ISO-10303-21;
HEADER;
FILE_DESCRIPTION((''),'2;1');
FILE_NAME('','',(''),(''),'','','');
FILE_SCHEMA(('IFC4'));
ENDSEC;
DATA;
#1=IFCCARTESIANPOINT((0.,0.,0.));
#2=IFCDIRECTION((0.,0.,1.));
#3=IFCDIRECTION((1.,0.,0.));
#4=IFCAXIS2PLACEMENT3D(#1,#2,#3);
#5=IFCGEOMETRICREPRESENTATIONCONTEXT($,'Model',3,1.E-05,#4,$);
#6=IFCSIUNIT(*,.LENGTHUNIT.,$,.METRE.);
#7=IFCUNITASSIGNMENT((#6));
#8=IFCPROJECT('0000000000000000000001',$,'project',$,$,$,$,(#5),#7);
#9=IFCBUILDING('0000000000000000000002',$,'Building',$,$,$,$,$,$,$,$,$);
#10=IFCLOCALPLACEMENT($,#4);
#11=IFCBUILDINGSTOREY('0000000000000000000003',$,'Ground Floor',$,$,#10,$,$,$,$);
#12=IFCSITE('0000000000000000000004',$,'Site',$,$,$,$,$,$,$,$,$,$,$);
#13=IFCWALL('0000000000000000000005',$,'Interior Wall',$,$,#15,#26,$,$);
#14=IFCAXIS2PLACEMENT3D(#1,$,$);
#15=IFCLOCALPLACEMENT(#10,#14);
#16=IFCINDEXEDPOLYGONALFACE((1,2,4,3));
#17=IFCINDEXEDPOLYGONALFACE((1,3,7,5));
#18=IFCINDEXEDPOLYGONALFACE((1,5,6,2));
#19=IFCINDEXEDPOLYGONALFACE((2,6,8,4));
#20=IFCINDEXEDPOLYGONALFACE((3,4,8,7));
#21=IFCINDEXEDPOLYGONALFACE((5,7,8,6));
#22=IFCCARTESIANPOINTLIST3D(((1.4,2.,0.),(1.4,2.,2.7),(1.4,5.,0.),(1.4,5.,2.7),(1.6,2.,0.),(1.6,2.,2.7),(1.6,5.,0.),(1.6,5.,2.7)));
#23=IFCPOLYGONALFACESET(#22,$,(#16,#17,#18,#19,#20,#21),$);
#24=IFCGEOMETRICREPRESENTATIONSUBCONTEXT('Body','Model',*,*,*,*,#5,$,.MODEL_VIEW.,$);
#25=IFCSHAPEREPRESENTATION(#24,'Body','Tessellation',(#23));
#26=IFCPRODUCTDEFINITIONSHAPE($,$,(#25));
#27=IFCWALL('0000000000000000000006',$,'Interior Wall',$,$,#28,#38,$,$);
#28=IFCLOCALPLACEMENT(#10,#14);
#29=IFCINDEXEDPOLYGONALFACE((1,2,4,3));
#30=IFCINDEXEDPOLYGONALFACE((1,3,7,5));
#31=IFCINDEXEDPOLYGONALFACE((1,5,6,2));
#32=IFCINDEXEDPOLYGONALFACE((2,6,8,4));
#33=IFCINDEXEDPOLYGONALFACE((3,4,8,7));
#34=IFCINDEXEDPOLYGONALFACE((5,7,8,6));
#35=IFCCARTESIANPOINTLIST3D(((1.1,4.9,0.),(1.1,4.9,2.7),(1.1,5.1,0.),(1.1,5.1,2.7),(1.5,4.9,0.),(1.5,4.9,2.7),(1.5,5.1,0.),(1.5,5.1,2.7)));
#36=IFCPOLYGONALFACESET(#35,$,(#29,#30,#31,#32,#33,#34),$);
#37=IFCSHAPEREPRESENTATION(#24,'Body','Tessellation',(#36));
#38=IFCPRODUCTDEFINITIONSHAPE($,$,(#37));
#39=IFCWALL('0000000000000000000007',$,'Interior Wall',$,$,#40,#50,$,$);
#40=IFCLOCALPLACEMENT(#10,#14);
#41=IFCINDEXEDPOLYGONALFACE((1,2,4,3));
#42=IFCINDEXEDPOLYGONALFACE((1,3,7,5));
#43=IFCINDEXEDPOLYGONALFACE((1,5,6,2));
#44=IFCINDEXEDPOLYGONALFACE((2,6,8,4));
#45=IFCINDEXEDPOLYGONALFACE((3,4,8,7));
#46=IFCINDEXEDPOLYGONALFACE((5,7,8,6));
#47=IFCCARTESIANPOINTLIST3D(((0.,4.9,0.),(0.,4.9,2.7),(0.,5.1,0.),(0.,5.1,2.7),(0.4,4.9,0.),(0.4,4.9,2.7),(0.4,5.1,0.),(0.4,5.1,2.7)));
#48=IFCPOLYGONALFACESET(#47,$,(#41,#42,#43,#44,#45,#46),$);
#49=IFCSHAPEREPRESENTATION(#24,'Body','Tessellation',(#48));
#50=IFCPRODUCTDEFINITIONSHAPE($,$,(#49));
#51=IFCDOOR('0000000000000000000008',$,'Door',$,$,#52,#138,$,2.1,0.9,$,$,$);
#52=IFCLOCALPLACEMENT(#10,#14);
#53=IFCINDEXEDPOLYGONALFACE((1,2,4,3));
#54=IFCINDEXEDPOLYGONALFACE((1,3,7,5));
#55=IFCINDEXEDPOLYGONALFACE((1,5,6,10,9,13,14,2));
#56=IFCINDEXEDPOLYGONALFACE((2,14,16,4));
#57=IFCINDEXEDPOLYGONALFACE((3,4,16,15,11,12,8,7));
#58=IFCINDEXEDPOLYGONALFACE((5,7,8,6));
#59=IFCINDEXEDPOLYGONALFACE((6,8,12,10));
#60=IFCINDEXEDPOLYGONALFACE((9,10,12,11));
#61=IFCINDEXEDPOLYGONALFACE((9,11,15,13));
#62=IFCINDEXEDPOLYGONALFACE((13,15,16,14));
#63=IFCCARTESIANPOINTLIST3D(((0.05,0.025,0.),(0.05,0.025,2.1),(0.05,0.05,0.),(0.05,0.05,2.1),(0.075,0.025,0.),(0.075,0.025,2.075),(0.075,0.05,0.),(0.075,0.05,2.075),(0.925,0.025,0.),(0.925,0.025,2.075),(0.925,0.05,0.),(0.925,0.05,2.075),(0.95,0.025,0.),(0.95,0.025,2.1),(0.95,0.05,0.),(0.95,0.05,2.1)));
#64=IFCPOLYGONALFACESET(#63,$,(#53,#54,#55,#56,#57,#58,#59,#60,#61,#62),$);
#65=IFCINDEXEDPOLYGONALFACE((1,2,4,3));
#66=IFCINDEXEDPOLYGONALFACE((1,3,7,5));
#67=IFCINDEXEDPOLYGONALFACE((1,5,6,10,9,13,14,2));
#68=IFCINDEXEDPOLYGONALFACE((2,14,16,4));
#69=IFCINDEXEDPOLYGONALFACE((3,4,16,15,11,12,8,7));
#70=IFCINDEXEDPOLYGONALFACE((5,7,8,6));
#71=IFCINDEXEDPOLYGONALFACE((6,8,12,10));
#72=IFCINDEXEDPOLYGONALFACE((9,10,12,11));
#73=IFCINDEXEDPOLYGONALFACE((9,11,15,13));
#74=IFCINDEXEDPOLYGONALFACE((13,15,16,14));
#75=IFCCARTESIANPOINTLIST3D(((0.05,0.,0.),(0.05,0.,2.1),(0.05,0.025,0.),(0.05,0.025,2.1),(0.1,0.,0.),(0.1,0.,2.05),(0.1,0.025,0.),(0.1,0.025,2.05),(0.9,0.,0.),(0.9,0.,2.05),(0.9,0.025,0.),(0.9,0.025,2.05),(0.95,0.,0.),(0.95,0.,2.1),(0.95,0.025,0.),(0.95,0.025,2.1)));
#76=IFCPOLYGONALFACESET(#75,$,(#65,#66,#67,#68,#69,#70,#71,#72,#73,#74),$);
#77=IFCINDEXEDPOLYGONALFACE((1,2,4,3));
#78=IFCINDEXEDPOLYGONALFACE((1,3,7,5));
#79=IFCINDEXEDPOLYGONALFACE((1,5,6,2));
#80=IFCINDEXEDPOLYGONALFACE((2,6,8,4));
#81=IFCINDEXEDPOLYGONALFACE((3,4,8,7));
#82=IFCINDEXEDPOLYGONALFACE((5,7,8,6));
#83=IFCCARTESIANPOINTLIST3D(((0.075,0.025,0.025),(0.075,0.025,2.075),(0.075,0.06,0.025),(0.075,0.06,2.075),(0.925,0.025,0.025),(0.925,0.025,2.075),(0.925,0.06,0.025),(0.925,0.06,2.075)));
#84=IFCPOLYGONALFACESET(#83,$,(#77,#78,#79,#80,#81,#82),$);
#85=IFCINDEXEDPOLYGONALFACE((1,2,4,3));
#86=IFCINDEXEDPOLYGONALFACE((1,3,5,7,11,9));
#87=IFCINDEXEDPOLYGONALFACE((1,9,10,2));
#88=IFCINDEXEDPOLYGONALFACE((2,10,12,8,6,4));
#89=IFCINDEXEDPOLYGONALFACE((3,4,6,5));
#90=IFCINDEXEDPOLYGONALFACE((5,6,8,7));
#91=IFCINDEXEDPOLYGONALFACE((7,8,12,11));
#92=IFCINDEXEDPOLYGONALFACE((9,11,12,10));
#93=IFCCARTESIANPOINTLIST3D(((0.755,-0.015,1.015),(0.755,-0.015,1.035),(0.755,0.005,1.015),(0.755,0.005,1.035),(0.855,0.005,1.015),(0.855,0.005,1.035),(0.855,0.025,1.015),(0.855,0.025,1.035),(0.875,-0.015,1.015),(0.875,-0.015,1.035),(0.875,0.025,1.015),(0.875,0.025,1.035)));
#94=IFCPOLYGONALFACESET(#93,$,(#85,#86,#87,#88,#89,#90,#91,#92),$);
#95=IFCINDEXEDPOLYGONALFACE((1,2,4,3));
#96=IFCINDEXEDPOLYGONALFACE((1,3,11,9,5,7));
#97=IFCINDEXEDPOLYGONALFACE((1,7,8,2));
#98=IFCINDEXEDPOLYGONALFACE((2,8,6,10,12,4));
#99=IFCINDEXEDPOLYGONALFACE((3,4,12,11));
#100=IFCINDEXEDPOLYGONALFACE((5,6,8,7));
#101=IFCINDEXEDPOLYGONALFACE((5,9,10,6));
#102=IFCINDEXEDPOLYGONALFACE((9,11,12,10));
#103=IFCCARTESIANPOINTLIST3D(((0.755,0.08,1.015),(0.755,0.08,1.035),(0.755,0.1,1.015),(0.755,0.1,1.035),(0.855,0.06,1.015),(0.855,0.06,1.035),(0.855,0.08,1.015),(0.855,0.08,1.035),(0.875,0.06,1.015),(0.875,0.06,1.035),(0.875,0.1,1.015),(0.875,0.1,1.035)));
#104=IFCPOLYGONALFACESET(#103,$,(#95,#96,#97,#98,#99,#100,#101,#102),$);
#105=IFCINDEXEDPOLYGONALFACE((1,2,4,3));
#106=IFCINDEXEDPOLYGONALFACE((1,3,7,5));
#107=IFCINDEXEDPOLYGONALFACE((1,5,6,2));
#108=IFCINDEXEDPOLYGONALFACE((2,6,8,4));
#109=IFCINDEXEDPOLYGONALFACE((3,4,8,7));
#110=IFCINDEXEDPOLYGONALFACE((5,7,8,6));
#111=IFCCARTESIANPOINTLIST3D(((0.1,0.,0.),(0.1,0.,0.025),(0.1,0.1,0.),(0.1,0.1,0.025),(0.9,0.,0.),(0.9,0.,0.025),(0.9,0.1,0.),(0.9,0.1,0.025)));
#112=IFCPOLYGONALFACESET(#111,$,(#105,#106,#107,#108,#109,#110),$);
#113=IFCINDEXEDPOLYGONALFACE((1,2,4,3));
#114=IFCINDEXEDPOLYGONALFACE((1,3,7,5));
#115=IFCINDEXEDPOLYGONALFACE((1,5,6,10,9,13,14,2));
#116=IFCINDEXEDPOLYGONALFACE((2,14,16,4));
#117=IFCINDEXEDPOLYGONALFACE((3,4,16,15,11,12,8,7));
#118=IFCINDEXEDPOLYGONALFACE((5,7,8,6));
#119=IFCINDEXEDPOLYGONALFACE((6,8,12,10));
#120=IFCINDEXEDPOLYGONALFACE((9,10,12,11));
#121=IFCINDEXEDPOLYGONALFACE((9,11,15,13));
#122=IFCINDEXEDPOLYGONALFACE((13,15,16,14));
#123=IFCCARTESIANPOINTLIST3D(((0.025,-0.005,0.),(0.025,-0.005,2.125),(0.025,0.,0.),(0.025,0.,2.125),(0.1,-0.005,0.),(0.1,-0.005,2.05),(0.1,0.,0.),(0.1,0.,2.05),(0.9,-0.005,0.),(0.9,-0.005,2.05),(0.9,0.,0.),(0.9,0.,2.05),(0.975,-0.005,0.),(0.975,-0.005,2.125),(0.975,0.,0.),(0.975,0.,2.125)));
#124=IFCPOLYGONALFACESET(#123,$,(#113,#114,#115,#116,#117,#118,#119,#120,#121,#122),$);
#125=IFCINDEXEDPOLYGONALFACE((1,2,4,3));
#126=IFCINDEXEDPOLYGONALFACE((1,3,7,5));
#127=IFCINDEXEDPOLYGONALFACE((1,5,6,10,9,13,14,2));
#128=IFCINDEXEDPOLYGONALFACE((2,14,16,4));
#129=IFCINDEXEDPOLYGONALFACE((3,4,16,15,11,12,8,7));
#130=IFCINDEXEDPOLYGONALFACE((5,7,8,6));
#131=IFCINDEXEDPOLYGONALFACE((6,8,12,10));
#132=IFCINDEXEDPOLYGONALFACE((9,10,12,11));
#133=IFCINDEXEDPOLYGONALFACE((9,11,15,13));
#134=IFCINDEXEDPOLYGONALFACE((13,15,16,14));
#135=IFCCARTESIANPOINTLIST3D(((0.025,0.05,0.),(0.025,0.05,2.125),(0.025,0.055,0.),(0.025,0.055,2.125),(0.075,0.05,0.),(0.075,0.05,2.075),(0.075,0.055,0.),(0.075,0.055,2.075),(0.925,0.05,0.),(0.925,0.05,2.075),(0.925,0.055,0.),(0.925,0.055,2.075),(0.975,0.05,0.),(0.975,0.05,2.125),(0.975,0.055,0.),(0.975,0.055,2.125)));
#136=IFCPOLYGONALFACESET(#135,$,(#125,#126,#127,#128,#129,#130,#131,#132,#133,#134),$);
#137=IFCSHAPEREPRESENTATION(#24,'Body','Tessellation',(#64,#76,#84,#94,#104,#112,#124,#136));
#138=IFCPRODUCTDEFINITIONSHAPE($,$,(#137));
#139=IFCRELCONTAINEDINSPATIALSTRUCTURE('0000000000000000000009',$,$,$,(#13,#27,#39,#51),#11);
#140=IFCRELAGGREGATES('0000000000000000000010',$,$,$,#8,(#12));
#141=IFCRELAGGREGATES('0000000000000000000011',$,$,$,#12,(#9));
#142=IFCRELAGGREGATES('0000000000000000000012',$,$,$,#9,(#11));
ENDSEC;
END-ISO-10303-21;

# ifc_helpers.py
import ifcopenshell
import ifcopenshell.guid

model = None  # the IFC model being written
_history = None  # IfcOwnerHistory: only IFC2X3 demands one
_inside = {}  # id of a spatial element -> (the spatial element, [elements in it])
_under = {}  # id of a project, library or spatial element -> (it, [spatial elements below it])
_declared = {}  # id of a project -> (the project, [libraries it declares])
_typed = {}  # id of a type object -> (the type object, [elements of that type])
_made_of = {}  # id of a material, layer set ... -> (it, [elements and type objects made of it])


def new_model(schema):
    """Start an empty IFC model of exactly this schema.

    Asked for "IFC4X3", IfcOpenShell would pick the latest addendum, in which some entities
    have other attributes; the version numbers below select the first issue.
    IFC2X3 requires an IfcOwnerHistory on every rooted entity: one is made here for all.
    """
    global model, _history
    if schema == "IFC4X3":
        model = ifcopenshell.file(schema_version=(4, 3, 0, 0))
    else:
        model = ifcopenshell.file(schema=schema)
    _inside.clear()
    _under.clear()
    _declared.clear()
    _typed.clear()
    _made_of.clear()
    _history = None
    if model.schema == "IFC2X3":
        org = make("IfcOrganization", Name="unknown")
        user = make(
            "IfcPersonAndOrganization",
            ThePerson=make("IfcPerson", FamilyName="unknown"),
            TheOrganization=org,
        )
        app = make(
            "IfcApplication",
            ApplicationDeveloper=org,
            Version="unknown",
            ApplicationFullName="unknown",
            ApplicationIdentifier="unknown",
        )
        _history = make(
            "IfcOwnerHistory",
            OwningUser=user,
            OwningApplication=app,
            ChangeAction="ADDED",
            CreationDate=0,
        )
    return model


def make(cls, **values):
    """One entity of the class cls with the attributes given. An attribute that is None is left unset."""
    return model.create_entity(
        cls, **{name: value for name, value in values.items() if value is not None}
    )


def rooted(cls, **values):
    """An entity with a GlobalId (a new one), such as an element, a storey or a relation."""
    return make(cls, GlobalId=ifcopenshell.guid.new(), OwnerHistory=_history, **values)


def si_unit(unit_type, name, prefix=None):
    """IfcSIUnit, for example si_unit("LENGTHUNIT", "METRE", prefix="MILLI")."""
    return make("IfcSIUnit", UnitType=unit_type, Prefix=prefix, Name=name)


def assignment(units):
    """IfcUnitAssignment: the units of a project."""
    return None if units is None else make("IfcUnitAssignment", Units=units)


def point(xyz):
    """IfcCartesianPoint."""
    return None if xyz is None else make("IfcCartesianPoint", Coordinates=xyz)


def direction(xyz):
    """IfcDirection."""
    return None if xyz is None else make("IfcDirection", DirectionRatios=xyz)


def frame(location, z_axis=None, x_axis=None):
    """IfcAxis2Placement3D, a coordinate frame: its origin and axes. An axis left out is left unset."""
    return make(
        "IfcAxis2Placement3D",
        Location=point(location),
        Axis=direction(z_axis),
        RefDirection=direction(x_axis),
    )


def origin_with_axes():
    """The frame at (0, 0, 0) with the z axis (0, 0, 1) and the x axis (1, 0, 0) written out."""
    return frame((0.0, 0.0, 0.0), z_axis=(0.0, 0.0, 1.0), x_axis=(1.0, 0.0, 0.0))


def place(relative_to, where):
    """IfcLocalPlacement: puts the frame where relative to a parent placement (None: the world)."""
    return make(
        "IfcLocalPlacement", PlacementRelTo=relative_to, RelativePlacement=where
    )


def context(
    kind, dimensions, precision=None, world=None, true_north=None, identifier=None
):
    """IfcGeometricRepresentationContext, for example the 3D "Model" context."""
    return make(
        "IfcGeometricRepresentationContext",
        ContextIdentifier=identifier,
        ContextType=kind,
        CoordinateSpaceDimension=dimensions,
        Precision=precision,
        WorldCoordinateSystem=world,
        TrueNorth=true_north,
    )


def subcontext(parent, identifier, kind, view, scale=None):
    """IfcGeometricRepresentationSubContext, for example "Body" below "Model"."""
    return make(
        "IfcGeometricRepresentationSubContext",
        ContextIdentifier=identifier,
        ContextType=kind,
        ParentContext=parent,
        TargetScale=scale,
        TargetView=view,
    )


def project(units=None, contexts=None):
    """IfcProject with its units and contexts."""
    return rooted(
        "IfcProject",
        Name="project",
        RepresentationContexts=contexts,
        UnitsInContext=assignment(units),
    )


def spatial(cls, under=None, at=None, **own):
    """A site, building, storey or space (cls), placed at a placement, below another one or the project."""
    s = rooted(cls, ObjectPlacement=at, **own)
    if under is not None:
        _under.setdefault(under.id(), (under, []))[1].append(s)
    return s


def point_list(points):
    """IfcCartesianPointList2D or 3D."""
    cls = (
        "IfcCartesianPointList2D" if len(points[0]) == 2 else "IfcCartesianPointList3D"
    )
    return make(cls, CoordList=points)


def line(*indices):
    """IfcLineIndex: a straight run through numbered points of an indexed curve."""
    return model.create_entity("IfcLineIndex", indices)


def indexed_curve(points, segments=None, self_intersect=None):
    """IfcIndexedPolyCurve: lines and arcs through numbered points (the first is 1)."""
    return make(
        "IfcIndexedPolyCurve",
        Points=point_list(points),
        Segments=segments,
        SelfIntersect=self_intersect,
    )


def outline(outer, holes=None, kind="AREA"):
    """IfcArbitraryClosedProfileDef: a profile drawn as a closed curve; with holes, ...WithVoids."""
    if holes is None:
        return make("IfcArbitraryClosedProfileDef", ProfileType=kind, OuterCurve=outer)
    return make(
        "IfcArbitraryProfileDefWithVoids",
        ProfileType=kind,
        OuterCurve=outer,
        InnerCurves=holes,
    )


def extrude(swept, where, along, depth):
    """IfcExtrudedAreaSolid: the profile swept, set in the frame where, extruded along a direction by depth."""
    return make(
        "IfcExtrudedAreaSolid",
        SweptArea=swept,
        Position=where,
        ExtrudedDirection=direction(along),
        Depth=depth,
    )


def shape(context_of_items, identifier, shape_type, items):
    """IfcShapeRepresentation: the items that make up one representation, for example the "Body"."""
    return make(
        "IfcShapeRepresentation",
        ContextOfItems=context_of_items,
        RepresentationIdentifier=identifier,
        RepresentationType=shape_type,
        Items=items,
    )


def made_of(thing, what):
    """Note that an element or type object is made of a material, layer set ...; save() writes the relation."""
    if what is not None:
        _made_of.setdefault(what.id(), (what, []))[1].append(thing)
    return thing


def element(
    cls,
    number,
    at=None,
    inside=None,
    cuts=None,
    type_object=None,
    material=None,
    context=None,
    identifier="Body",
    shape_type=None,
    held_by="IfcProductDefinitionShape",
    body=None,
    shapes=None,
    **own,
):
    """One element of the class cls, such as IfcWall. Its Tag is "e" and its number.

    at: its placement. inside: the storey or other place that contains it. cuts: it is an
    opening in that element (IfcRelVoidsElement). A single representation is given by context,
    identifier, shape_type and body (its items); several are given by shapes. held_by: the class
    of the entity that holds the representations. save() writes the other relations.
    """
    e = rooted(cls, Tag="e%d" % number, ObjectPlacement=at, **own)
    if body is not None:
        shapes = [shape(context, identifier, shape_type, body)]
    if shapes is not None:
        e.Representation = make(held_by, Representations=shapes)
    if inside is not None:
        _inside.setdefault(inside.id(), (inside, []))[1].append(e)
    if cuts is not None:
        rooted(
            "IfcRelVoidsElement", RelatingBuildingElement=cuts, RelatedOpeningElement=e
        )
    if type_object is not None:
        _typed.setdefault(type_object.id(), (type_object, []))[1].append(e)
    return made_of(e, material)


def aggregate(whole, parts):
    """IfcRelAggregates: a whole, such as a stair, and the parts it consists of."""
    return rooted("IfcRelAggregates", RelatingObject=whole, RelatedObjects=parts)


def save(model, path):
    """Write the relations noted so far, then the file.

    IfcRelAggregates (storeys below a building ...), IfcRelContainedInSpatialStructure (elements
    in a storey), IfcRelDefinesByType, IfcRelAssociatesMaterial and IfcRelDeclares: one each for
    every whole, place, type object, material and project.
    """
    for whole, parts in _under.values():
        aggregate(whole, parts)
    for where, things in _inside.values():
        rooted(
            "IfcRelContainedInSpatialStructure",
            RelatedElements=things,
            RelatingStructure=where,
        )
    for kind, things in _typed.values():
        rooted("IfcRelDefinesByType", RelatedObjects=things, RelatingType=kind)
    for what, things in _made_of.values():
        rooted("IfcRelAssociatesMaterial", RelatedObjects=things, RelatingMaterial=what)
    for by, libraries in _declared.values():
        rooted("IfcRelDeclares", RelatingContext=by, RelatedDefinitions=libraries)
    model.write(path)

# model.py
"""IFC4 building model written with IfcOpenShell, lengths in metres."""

from ifc_helpers import new_model, si_unit, frame, origin_with_axes, place, context, subcontext, project, spatial, line, indexed_curve, outline, extrude, element, save


model = new_model("IFC4")

# Units and contexts
model_context = context("Model", 3, precision=1e-05, world=origin_with_axes())
body_context = subcontext(model_context, "Body", "Model", "MODEL_VIEW")
ifc_project = project(units=[si_unit("LENGTHUNIT", "METRE")], contexts=[model_context])

# Site, building, storey
site = spatial("IfcSite", under=ifc_project, Name="Site")
building = spatial("IfcBuilding", under=site, Name="Building")
storey_placement = place(None, origin_with_axes())
storey = spatial("IfcBuildingStorey", under=building, at=storey_placement, Name="Ground Floor")

# Walls
wall_1_placement = place(storey_placement, frame((1.5, 5.0, 0.0), z_axis=(0.0, 0.0, 1.0), x_axis=(0.0, -1.0, 0.0)))
element("IfcWall", 1, at=wall_1_placement, inside=storey, Name="Interior Wall", context=body_context, shape_type="SweptSolid", body=[
    extrude(outline(indexed_curve([(0.0, 0.0), (0.0, 0.2), (3.0, 0.2), (3.0, 0.0), (0.0, 0.0)], self_intersect=False)), frame((0.0, -0.1, 0.0), z_axis=(0.0, 0.0, 1.0), x_axis=(1.0, 0.0, 0.0)), (0.0, 0.0, 1.0), 2.7),
])
for number, where, z_axis, x_axis, name in (
    (2, (1.5, 5.0, 0.0), (0.0, 0.0, 1.0), (-1.0, 0.0, 0.0), "Interior Wall"),
    (3, (0.4, 5.0, 0.0), (0.0, 0.0, 1.0), (-1.0, 0.0, 0.0), "Interior Wall"),
):
    element("IfcWall", number, at=place(storey_placement, frame(where, z_axis=z_axis, x_axis=x_axis)), inside=storey, Name=name, context=body_context, shape_type="SweptSolid", body=[
        extrude(outline(indexed_curve([(0.0, 0.0), (0.0, 0.2), (0.4, 0.2), (0.4, 0.0), (0.0, 0.0)], self_intersect=False)), frame((0.0, -0.1, 0.0), z_axis=(0.0, 0.0, 1.0), x_axis=(1.0, 0.0, 0.0)), (0.0, 0.0, 1.0), 2.7),
    ])

# Door
door_1_placement = place(storey_placement, frame((0.05, 0.0, 0.0), z_axis=(0.0, 0.0, 1.0), x_axis=(1.0, 0.0, 0.0)))
element("IfcDoor", 4, at=door_1_placement, inside=storey, Name="Door", OverallHeight=2.1, OverallWidth=0.9, context=body_context, shape_type="SweptSolid", body=[
    extrude(outline(indexed_curve([(0.0, 0.0), (0.0, 2.1), (0.9, 2.1), (0.9, 0.0), (0.875, 0.0), (0.875, 2.075), (0.025, 2.075), (0.025, 0.0)], segments=[line(1, 2, 3, 4, 5, 6, 7, 8, 1)])), frame((0.0, 0.025, 0.0), z_axis=(0.0, -1.0, 0.0), x_axis=(1.0, 0.0, 0.0)), (0.0, 0.0, -1.0), 0.025),
    extrude(outline(indexed_curve([(0.0, 0.0), (0.0, 2.1), (0.9, 2.1), (0.9, 0.0), (0.85, 0.0), (0.85, 2.05), (0.05, 2.05), (0.05, 0.0)], segments=[line(1, 2, 3, 4, 5, 6, 7, 8, 1)])), frame((0.0, 0.0, 0.0), z_axis=(0.0, -1.0, 0.0), x_axis=(1.0, 0.0, 0.0)), (0.0, 0.0, -1.0), 0.025),
    extrude(outline(indexed_curve([(0.0, 0.0), (0.85, 0.0), (0.85, 0.035), (0.0, 0.035)], segments=[line(1, 2, 3, 4, 1)])), frame((0.025, 0.025, 0.025), z_axis=(0.0, 0.0, 1.0), x_axis=(1.0, 0.0, 0.0)), (0.0, 0.0, 1.0), 2.05),
    extrude(outline(indexed_curve([(0.0, 0.0), (0.0, -0.04), (-0.12, -0.04), (-0.12, -0.02), (-0.02, -0.02), (-0.02, 0.0)], segments=[line(1, 2, 3, 4, 5, 6, 1)])), frame((0.825, 0.025, 1.015), z_axis=(0.0, 0.0, 1.0), x_axis=(1.0, 0.0, 0.0)), (0.0, 0.0, 1.0), 0.02),
    extrude(outline(indexed_curve([(0.0, 0.0), (0.0, 0.04), (-0.12, 0.04), (-0.12, 0.02), (-0.02, 0.02), (-0.02, 0.0)], segments=[line(1, 2, 3, 4, 5, 6, 1)])), frame((0.825, 0.06, 1.015), z_axis=(0.0, 0.0, 1.0), x_axis=(1.0, 0.0, 0.0)), (0.0, 0.0, 1.0), 0.02),
    extrude(outline(indexed_curve([(0.0, 0.0), (0.8, 0.0), (0.8, 0.1), (0.0, 0.1)], segments=[line(1, 2, 3, 4, 1)])), frame((0.05, 0.0, 0.0), z_axis=(0.0, 0.0, 1.0), x_axis=(1.0, 0.0, 0.0)), (0.0, 0.0, 1.0), 0.025),
    extrude(outline(indexed_curve([(0.0, 0.0), (0.0, 2.125), (0.95, 2.125), (0.95, 0.0), (0.875, 0.0), (0.875, 2.05), (0.075, 2.05), (0.075, 0.0)], segments=[line(1, 2, 3, 4, 5, 6, 7, 8, 1)])), frame((-0.025, -0.005, 0.0), z_axis=(0.0, -1.0, 0.0), x_axis=(1.0, 0.0, 0.0)), (0.0, 0.0, -1.0), 0.005),
    extrude(outline(indexed_curve([(0.0, 0.0), (0.0, 2.125), (0.95, 2.125), (0.95, 0.0), (0.9, 0.0), (0.9, 2.075), (0.05, 2.075), (0.05, 0.0)], segments=[line(1, 2, 3, 4, 5, 6, 7, 8, 1)])), frame((-0.025, 0.05, 0.0), z_axis=(0.0, -1.0, 0.0), x_axis=(1.0, 0.0, 0.0)), (0.0, 0.0, -1.0), 0.005),
])

save(model, "model.ifc")
